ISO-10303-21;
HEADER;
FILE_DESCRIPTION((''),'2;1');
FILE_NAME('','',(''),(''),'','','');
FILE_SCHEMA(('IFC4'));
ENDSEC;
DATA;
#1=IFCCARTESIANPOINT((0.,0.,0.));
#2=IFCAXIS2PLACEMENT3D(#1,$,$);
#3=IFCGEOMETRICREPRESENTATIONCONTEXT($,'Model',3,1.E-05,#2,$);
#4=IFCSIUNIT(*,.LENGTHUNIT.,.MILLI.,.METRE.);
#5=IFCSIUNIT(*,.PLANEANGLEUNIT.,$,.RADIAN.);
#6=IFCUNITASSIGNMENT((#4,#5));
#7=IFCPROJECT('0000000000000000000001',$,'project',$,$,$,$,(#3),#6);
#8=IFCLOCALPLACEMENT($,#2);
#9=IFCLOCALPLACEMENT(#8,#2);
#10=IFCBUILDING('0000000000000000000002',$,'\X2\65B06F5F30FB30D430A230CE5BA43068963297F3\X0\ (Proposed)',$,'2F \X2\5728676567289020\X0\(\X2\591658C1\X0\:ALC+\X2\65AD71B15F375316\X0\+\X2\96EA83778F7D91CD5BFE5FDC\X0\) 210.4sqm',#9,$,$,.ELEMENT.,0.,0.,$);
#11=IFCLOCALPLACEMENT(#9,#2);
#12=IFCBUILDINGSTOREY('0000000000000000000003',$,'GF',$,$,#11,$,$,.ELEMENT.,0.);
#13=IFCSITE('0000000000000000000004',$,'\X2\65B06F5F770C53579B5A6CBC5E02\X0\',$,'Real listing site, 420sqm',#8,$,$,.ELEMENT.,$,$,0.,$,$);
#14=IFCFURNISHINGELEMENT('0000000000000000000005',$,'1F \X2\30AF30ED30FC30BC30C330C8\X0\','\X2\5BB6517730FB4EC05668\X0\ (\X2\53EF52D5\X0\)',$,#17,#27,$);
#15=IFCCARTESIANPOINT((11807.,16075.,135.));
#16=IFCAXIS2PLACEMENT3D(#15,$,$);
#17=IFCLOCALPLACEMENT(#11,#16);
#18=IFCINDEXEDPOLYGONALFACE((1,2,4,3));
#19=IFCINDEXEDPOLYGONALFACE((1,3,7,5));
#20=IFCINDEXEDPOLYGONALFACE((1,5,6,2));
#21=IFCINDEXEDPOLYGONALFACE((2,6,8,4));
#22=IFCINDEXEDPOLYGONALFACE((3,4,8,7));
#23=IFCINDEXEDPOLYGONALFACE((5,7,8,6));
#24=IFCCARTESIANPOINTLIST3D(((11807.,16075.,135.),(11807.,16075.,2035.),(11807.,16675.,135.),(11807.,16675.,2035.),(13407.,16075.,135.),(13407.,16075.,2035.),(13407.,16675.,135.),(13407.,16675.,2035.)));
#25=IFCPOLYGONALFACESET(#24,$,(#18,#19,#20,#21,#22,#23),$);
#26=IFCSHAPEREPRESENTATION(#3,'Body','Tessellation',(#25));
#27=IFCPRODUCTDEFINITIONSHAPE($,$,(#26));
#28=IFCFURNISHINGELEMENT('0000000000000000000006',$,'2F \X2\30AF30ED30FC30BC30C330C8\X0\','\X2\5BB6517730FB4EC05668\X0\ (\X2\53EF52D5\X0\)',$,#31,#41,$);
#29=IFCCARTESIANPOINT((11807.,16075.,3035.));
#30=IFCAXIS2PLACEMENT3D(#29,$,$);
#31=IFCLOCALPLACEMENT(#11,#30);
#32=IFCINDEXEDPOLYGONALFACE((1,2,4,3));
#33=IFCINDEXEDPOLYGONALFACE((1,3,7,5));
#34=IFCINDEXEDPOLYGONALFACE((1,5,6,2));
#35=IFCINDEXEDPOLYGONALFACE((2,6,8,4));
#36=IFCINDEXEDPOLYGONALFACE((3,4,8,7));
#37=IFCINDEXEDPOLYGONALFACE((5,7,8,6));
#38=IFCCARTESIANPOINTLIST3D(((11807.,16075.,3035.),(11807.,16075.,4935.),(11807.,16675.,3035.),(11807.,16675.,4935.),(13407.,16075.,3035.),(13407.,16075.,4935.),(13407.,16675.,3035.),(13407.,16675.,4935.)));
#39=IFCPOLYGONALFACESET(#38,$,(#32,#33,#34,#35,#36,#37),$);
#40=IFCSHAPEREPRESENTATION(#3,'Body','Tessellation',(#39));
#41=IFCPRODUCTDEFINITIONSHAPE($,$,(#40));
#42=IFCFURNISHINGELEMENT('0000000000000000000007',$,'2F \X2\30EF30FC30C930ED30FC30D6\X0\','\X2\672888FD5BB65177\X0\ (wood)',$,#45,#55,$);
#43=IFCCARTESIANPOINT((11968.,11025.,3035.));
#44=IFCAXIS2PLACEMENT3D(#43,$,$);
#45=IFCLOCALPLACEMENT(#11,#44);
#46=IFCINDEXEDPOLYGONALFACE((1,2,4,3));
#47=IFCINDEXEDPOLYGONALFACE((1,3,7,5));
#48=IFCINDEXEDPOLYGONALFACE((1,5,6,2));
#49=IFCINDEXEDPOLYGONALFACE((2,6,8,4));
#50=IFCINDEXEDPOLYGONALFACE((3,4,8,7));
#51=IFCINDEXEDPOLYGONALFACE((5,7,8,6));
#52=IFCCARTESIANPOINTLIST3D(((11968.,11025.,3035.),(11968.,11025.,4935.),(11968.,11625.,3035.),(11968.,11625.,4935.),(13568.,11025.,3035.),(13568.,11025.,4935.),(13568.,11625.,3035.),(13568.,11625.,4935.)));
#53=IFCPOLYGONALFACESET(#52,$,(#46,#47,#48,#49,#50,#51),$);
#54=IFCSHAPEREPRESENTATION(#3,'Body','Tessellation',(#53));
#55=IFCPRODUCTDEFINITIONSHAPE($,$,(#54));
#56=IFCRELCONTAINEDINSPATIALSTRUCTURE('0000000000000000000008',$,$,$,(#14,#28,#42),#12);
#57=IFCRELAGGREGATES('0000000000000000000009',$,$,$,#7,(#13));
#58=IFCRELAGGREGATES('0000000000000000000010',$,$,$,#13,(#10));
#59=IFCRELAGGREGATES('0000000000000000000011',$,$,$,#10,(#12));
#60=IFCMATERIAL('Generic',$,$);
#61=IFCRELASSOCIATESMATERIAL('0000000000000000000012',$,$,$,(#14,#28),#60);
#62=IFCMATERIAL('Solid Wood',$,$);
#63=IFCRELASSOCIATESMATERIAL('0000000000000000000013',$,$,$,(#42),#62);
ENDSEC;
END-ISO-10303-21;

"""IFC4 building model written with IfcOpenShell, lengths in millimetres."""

from ifc_helpers import new_model, si_unit, frame, frame_2d, origin, place, context, project, spatial, rectangle, extrude, material, element, save


model = new_model("IFC4")

# Units and contexts
model_context = context("Model", 3, precision=1e-05, world=origin())
ifc_project = project(units=[si_unit("LENGTHUNIT", "METRE", prefix="MILLI"), si_unit("PLANEANGLEUNIT", "RADIAN")], contexts=[model_context])

# Site, building, storey
site_placement = place(None, origin())
site = spatial("IfcSite", under=ifc_project, at=site_placement, Name="新潟県南魚沼市", ObjectType="Real listing site, 420sqm", CompositionType="ELEMENT", RefElevation=0.0)
building_placement = place(site_placement, origin())
building = spatial("IfcBuilding", under=site, at=building_placement, Name="新潟・ピアノ室と防音 (Proposed)", ObjectType="2F 在来木造(外壁:ALC+断熱強化+雪荷载重対応) 210.4sqm", CompositionType="ELEMENT", ElevationOfRefHeight=0.0, ElevationOfTerrain=0.0)
storey_placement = place(building_placement, origin())
storey = spatial("IfcBuildingStorey", under=building, at=storey_placement, Name="GF", CompositionType="ELEMENT", Elevation=0.0)

# Shared definitions
ifc_material_1 = material(Name="Solid Wood")

# Shared definitions
ifc_material_2 = material(Name="Generic")

# Furnishing elements
furnishing_1_placement = place(storey_placement, frame((11807.0, 16075.0, 135.0)))
element("IfcFurnishingElement", 1, at=furnishing_1_placement, inside=storey, material=ifc_material_2, Name="1F クローゼット", Description="家具・什器 (可動)", context=model_context, shape_type="SweptSolid", body=[
    extrude(rectangle(XDim=1600.0, YDim=600.0, at=frame_2d((800.0, 300.0))), frame((11807.0, 16075.0, 135.0)), (0.0, 0.0, 1.0), 1900.0),
])
furnishing_2_placement = place(storey_placement, frame((11807.0, 16075.0, 3035.0)))
element("IfcFurnishingElement", 2, at=furnishing_2_placement, inside=storey, material=ifc_material_2, Name="2F クローゼット", Description="家具・什器 (可動)", context=model_context, shape_type="SweptSolid", body=[
    extrude(rectangle(XDim=1600.0, YDim=600.0, at=frame_2d((800.0, 300.0))), frame((11807.0, 16075.0, 3035.0)), (0.0, 0.0, 1.0), 1900.0),
])
furnishing_3_placement = place(storey_placement, frame((11968.0, 11025.0, 3035.0)))
element("IfcFurnishingElement", 3, at=furnishing_3_placement, inside=storey, material=ifc_material_1, Name="2F ワードローブ", Description="木製家具 (wood)", context=model_context, shape_type="SweptSolid", body=[
    extrude(rectangle(XDim=1600.0, YDim=600.0, at=frame_2d((800.0, 300.0))), frame((11968.0, 11025.0, 3035.0)), (0.0, 0.0, 1.0), 1900.0),
])

save(model, "model.ifc")
